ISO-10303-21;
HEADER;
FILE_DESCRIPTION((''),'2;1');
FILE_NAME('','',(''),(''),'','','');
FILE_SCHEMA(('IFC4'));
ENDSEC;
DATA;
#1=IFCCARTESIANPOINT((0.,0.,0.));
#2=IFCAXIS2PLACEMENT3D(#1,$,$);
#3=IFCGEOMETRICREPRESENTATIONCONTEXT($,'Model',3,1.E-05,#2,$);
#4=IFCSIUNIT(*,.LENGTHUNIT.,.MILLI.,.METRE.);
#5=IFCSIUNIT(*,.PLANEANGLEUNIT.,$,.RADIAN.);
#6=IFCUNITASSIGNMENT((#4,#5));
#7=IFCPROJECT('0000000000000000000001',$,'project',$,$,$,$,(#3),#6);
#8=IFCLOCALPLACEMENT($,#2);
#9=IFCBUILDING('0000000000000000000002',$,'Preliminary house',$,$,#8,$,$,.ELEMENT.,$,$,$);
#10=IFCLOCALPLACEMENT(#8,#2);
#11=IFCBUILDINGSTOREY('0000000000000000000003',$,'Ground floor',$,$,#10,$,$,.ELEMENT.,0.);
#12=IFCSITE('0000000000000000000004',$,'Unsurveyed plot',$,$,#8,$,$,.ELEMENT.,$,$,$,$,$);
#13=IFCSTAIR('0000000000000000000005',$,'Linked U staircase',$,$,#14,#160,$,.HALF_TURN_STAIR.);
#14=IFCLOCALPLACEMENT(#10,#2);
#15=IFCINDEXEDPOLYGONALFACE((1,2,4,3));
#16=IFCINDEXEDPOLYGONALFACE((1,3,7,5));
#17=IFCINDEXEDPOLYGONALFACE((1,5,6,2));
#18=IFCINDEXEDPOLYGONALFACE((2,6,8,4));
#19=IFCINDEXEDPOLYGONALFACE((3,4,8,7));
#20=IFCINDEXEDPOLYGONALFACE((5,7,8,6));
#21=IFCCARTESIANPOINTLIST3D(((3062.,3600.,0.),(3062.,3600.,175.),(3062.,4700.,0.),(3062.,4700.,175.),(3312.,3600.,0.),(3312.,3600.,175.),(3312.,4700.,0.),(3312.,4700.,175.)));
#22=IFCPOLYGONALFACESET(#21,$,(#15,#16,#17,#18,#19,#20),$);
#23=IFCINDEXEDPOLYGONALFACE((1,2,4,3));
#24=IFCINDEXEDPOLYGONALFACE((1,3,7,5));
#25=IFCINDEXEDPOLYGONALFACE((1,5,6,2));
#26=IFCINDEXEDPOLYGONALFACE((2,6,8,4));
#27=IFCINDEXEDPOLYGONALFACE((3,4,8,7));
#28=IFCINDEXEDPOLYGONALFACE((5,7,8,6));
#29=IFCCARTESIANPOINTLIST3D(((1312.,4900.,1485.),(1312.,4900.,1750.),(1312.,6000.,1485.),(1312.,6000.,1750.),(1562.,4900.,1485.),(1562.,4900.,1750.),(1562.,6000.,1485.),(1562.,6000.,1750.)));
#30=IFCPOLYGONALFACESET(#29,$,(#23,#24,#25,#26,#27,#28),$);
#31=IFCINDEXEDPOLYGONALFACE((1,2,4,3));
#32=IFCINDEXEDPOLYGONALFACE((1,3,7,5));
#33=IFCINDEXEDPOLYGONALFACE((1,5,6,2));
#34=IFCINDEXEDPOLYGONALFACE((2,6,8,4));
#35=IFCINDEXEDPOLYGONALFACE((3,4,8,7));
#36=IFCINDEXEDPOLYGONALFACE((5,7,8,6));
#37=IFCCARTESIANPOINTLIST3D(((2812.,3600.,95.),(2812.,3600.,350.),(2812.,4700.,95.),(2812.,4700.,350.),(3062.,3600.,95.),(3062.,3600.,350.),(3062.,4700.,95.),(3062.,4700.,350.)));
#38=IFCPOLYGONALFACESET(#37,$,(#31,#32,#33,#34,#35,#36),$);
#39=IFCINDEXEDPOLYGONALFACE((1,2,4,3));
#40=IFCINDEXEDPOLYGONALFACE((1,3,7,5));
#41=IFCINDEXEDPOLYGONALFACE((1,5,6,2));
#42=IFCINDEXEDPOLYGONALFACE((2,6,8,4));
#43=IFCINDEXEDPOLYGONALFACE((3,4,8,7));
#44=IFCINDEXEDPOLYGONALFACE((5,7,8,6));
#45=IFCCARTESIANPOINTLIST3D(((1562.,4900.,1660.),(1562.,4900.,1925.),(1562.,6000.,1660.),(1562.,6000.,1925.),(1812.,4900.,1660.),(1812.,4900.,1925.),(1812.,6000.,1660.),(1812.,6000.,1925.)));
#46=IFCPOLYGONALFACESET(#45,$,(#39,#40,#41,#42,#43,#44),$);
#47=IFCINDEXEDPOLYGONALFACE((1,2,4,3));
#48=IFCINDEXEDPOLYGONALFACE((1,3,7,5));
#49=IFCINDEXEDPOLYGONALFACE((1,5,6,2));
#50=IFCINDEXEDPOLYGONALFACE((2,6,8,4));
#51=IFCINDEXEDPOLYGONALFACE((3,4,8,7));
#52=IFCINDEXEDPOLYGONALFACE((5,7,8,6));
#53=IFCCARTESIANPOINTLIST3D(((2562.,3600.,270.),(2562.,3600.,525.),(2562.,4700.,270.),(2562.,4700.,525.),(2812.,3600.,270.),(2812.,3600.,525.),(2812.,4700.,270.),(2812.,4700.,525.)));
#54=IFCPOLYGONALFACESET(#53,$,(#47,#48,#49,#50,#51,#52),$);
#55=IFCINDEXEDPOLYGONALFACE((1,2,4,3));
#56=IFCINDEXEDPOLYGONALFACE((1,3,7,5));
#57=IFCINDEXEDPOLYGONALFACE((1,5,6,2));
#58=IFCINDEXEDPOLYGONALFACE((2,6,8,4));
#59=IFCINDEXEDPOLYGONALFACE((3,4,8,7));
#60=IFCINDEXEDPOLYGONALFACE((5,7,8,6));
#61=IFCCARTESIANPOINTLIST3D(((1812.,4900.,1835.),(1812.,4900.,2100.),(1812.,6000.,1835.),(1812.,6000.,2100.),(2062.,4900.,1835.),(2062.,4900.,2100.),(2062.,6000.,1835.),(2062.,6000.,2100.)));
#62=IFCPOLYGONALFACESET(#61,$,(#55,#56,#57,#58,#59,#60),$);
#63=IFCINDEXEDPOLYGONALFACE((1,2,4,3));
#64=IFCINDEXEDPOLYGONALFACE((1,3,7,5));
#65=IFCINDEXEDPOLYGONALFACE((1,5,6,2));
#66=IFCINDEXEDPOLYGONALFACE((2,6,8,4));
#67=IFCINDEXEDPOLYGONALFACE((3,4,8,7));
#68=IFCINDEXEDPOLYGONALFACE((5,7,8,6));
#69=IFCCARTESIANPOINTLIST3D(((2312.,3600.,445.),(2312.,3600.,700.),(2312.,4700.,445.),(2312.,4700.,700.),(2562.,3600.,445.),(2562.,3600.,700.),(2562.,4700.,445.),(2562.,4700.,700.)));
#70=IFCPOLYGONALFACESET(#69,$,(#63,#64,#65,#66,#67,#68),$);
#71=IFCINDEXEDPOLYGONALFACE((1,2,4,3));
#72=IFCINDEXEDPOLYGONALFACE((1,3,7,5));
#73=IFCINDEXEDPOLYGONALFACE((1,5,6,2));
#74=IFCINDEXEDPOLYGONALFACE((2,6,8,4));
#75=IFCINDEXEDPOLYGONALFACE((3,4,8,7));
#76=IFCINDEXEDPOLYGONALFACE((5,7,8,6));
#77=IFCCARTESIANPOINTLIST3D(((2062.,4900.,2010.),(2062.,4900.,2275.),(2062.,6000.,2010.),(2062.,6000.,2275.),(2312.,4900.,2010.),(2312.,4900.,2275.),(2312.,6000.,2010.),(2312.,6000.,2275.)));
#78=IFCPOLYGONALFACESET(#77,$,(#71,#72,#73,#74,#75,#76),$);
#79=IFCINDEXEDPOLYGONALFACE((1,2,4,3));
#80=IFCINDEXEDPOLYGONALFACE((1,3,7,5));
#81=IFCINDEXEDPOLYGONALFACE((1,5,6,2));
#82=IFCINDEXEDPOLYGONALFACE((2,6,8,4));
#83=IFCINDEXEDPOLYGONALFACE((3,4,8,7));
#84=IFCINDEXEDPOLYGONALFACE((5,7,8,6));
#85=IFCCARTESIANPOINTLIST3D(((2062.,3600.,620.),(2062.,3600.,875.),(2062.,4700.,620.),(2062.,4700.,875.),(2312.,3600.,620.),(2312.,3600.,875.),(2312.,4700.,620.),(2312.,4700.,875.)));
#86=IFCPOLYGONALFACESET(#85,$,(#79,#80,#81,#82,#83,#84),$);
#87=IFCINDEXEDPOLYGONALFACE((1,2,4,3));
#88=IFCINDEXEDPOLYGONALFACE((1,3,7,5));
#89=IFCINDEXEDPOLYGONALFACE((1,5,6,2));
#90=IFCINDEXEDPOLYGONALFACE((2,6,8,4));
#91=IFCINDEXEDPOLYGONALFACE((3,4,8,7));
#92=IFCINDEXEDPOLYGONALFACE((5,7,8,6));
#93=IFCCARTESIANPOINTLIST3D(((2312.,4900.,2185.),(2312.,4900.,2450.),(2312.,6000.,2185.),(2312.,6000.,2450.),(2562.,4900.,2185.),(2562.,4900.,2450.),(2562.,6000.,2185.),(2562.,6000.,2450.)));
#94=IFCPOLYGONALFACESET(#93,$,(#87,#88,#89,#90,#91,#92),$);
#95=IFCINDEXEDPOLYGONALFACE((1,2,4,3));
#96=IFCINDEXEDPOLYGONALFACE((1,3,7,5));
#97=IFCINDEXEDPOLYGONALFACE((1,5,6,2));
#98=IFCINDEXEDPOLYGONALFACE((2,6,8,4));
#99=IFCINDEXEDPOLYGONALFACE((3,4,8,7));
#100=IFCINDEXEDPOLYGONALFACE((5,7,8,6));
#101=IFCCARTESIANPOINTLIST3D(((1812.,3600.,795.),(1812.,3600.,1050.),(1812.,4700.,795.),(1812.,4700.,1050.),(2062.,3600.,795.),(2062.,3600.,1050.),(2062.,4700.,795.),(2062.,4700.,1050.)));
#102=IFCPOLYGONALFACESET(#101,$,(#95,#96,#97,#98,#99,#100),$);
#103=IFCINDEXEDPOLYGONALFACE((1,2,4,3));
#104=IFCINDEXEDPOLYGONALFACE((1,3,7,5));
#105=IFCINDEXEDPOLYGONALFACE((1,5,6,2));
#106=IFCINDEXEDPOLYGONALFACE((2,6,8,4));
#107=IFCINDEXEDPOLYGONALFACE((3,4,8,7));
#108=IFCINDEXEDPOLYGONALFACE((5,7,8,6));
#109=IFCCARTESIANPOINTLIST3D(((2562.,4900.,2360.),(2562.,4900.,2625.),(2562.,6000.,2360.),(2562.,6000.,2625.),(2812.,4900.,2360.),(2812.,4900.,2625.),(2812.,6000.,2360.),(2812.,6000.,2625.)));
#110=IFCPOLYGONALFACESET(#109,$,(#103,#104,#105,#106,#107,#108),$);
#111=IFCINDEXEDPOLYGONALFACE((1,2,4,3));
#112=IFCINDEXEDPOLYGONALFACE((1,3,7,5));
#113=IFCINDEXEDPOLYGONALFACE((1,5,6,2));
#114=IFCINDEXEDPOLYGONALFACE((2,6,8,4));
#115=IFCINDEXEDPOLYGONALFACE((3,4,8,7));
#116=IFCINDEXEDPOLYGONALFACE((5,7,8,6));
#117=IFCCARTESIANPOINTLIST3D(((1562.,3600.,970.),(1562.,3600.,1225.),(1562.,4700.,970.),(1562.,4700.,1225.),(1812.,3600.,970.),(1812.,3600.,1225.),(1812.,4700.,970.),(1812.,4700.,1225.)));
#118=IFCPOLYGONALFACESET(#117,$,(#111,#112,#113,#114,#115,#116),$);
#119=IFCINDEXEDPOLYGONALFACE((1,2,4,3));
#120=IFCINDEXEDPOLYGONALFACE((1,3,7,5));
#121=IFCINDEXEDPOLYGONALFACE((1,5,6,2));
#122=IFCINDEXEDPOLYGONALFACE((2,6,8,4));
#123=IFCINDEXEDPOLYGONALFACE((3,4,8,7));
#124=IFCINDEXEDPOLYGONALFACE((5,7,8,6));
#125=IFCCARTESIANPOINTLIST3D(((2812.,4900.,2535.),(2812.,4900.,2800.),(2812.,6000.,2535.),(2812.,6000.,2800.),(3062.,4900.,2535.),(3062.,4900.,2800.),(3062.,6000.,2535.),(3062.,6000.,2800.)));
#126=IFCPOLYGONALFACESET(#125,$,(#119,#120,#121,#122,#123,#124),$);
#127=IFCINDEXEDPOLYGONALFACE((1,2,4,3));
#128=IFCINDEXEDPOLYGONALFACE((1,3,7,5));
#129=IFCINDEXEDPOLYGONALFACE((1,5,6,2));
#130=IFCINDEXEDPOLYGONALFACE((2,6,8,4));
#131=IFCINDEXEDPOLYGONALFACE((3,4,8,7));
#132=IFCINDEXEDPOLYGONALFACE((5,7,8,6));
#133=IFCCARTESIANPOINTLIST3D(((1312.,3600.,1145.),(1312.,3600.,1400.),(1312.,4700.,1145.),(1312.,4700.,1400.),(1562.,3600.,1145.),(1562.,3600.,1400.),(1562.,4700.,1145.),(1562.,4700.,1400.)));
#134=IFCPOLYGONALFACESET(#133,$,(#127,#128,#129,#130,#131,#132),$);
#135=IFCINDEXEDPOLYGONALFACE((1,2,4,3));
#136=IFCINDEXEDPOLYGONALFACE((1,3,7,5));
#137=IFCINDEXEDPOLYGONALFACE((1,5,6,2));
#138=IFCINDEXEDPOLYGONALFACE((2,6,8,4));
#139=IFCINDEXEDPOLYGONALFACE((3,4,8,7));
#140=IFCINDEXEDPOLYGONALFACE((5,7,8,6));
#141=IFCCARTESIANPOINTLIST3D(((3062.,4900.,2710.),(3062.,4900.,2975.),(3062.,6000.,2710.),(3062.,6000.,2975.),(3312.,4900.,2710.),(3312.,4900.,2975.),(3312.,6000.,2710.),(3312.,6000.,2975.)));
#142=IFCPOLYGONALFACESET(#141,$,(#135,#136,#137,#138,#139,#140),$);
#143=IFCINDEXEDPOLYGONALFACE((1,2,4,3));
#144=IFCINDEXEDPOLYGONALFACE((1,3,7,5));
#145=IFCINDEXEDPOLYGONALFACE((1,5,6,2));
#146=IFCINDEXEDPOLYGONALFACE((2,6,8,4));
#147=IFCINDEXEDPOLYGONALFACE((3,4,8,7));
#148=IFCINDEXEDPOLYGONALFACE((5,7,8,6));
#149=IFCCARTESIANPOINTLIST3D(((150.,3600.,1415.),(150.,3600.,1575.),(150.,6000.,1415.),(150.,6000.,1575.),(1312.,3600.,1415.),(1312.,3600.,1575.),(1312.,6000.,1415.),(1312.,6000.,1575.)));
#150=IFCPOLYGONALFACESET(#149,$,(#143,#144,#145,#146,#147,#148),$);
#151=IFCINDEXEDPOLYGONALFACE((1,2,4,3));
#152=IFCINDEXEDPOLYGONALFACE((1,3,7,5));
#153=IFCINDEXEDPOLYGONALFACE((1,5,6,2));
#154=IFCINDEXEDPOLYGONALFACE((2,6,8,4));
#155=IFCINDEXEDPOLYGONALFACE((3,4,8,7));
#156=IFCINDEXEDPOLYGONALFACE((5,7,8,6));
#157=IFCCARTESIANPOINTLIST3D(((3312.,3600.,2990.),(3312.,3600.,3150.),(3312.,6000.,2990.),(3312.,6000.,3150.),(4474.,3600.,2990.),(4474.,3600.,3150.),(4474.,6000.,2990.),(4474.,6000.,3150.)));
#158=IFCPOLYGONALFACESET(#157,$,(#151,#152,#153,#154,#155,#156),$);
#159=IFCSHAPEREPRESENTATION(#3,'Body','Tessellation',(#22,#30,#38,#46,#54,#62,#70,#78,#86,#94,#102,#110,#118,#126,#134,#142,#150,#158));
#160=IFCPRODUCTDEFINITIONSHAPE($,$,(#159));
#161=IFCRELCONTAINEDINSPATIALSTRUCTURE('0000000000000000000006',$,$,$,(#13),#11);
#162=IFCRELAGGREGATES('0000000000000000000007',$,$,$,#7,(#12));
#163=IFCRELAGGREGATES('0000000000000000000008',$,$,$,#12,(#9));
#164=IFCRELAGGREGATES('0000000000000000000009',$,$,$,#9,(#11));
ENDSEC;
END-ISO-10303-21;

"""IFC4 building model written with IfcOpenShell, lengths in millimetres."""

from ifc_helpers import new_model, si_unit, frame, origin, place, context, project, spatial, polyline, outline, extrude, element, save


model = new_model("IFC4")

# Units and contexts
model_context = context("Model", 3, precision=1e-05, world=origin())
ifc_project = project(units=[si_unit("LENGTHUNIT", "METRE", prefix="MILLI"), si_unit("PLANEANGLEUNIT", "RADIAN")], contexts=[model_context])

# Site, building, storey
placement_1 = place(None, origin())
site = spatial("IfcSite", under=ifc_project, at=placement_1, Name="Unsurveyed plot", CompositionType="ELEMENT")
building = spatial("IfcBuilding", under=site, at=placement_1, Name="Preliminary house", CompositionType="ELEMENT")
placement_2 = place(placement_1, origin())
storey = spatial("IfcBuildingStorey", under=building, at=placement_2, Name="Ground floor", CompositionType="ELEMENT", Elevation=0.0)

# Stair
element("IfcStair", 1, at=placement_2, inside=storey, Name="Linked U staircase", PredefinedType="HALF_TURN_STAIR", context=model_context, shape_type="SweptSolid", body=[
    extrude(outline(polyline([(3312.0, 4700.0), (3062.0, 4700.0), (3062.0, 3600.0), (3312.0, 3600.0), (3312.0, 4700.0)])), origin(), (0.0, 0.0, 1.0), 175.0),
    extrude(outline(polyline([(1562.0, 6000.0), (1312.0, 6000.0), (1312.0, 4900.0), (1562.0, 4900.0), (1562.0, 6000.0)])), frame((0.0, 0.0, 1485.0)), (0.0, 0.0, 1.0), 265.0),
    extrude(outline(polyline([(3062.0, 4700.0), (2812.0, 4700.0), (2812.0, 3600.0), (3062.0, 3600.0), (3062.0, 4700.0)])), frame((0.0, 0.0, 95.0)), (0.0, 0.0, 1.0), 255.0),
    extrude(outline(polyline([(1812.0, 6000.0), (1562.0, 6000.0), (1562.0, 4900.0), (1812.0, 4900.0), (1812.0, 6000.0)])), frame((0.0, 0.0, 1660.0)), (0.0, 0.0, 1.0), 265.0),
    extrude(outline(polyline([(2812.0, 4700.0), (2562.0, 4700.0), (2562.0, 3600.0), (2812.0, 3600.0), (2812.0, 4700.0)])), frame((0.0, 0.0, 270.0)), (0.0, 0.0, 1.0), 255.0),
    extrude(outline(polyline([(2062.0, 6000.0), (1812.0, 6000.0), (1812.0, 4900.0), (2062.0, 4900.0), (2062.0, 6000.0)])), frame((0.0, 0.0, 1835.0)), (0.0, 0.0, 1.0), 265.0),
    extrude(outline(polyline([(2562.0, 4700.0), (2312.0, 4700.0), (2312.0, 3600.0), (2562.0, 3600.0), (2562.0, 4700.0)])), frame((0.0, 0.0, 445.0)), (0.0, 0.0, 1.0), 255.0),
    extrude(outline(polyline([(2312.0, 6000.0), (2062.0, 6000.0), (2062.0, 4900.0), (2312.0, 4900.0), (2312.0, 6000.0)])), frame((0.0, 0.0, 2010.0)), (0.0, 0.0, 1.0), 265.0),
    extrude(outline(polyline([(2312.0, 4700.0), (2062.0, 4700.0), (2062.0, 3600.0), (2312.0, 3600.0), (2312.0, 4700.0)])), frame((0.0, 0.0, 620.0)), (0.0, 0.0, 1.0), 255.0),
    extrude(outline(polyline([(2562.0, 6000.0), (2312.0, 6000.0), (2312.0, 4900.0), (2562.0, 4900.0), (2562.0, 6000.0)])), frame((0.0, 0.0, 2185.0)), (0.0, 0.0, 1.0), 265.0),
    extrude(outline(polyline([(2062.0, 4700.0), (1812.0, 4700.0), (1812.0, 3600.0), (2062.0, 3600.0), (2062.0, 4700.0)])), frame((0.0, 0.0, 795.0)), (0.0, 0.0, 1.0), 255.0),
    extrude(outline(polyline([(2812.0, 6000.0), (2562.0, 6000.0), (2562.0, 4900.0), (2812.0, 4900.0), (2812.0, 6000.0)])), frame((0.0, 0.0, 2360.0)), (0.0, 0.0, 1.0), 265.0),
    extrude(outline(polyline([(1812.0, 4700.0), (1562.0, 4700.0), (1562.0, 3600.0), (1812.0, 3600.0), (1812.0, 4700.0)])), frame((0.0, 0.0, 970.0)), (0.0, 0.0, 1.0), 255.0),
    extrude(outline(polyline([(3062.0, 6000.0), (2812.0, 6000.0), (2812.0, 4900.0), (3062.0, 4900.0), (3062.0, 6000.0)])), frame((0.0, 0.0, 2535.0)), (0.0, 0.0, 1.0), 265.0),
    extrude(outline(polyline([(1562.0, 4700.0), (1312.0, 4700.0), (1312.0, 3600.0), (1562.0, 3600.0), (1562.0, 4700.0)])), frame((0.0, 0.0, 1145.0)), (0.0, 0.0, 1.0), 255.0),
    extrude(outline(polyline([(3312.0, 6000.0), (3062.0, 6000.0), (3062.0, 4900.0), (3312.0, 4900.0), (3312.0, 6000.0)])), frame((0.0, 0.0, 2710.0)), (0.0, 0.0, 1.0), 265.0),
    extrude(outline(polyline([(1312.0, 6000.0), (150.0, 6000.0), (150.0, 3600.0), (1312.0, 3600.0), (1312.0, 6000.0)])), frame((0.0, 0.0, 1415.0)), (0.0, 0.0, 1.0), 160.0),
    extrude(outline(polyline([(4474.0, 6000.0), (3312.0, 6000.0), (3312.0, 3600.0), (4474.0, 3600.0), (4474.0, 6000.0)])), frame((0.0, 0.0, 2990.0)), (0.0, 0.0, 1.0), 160.0),
])

save(model, "model.ifc")
